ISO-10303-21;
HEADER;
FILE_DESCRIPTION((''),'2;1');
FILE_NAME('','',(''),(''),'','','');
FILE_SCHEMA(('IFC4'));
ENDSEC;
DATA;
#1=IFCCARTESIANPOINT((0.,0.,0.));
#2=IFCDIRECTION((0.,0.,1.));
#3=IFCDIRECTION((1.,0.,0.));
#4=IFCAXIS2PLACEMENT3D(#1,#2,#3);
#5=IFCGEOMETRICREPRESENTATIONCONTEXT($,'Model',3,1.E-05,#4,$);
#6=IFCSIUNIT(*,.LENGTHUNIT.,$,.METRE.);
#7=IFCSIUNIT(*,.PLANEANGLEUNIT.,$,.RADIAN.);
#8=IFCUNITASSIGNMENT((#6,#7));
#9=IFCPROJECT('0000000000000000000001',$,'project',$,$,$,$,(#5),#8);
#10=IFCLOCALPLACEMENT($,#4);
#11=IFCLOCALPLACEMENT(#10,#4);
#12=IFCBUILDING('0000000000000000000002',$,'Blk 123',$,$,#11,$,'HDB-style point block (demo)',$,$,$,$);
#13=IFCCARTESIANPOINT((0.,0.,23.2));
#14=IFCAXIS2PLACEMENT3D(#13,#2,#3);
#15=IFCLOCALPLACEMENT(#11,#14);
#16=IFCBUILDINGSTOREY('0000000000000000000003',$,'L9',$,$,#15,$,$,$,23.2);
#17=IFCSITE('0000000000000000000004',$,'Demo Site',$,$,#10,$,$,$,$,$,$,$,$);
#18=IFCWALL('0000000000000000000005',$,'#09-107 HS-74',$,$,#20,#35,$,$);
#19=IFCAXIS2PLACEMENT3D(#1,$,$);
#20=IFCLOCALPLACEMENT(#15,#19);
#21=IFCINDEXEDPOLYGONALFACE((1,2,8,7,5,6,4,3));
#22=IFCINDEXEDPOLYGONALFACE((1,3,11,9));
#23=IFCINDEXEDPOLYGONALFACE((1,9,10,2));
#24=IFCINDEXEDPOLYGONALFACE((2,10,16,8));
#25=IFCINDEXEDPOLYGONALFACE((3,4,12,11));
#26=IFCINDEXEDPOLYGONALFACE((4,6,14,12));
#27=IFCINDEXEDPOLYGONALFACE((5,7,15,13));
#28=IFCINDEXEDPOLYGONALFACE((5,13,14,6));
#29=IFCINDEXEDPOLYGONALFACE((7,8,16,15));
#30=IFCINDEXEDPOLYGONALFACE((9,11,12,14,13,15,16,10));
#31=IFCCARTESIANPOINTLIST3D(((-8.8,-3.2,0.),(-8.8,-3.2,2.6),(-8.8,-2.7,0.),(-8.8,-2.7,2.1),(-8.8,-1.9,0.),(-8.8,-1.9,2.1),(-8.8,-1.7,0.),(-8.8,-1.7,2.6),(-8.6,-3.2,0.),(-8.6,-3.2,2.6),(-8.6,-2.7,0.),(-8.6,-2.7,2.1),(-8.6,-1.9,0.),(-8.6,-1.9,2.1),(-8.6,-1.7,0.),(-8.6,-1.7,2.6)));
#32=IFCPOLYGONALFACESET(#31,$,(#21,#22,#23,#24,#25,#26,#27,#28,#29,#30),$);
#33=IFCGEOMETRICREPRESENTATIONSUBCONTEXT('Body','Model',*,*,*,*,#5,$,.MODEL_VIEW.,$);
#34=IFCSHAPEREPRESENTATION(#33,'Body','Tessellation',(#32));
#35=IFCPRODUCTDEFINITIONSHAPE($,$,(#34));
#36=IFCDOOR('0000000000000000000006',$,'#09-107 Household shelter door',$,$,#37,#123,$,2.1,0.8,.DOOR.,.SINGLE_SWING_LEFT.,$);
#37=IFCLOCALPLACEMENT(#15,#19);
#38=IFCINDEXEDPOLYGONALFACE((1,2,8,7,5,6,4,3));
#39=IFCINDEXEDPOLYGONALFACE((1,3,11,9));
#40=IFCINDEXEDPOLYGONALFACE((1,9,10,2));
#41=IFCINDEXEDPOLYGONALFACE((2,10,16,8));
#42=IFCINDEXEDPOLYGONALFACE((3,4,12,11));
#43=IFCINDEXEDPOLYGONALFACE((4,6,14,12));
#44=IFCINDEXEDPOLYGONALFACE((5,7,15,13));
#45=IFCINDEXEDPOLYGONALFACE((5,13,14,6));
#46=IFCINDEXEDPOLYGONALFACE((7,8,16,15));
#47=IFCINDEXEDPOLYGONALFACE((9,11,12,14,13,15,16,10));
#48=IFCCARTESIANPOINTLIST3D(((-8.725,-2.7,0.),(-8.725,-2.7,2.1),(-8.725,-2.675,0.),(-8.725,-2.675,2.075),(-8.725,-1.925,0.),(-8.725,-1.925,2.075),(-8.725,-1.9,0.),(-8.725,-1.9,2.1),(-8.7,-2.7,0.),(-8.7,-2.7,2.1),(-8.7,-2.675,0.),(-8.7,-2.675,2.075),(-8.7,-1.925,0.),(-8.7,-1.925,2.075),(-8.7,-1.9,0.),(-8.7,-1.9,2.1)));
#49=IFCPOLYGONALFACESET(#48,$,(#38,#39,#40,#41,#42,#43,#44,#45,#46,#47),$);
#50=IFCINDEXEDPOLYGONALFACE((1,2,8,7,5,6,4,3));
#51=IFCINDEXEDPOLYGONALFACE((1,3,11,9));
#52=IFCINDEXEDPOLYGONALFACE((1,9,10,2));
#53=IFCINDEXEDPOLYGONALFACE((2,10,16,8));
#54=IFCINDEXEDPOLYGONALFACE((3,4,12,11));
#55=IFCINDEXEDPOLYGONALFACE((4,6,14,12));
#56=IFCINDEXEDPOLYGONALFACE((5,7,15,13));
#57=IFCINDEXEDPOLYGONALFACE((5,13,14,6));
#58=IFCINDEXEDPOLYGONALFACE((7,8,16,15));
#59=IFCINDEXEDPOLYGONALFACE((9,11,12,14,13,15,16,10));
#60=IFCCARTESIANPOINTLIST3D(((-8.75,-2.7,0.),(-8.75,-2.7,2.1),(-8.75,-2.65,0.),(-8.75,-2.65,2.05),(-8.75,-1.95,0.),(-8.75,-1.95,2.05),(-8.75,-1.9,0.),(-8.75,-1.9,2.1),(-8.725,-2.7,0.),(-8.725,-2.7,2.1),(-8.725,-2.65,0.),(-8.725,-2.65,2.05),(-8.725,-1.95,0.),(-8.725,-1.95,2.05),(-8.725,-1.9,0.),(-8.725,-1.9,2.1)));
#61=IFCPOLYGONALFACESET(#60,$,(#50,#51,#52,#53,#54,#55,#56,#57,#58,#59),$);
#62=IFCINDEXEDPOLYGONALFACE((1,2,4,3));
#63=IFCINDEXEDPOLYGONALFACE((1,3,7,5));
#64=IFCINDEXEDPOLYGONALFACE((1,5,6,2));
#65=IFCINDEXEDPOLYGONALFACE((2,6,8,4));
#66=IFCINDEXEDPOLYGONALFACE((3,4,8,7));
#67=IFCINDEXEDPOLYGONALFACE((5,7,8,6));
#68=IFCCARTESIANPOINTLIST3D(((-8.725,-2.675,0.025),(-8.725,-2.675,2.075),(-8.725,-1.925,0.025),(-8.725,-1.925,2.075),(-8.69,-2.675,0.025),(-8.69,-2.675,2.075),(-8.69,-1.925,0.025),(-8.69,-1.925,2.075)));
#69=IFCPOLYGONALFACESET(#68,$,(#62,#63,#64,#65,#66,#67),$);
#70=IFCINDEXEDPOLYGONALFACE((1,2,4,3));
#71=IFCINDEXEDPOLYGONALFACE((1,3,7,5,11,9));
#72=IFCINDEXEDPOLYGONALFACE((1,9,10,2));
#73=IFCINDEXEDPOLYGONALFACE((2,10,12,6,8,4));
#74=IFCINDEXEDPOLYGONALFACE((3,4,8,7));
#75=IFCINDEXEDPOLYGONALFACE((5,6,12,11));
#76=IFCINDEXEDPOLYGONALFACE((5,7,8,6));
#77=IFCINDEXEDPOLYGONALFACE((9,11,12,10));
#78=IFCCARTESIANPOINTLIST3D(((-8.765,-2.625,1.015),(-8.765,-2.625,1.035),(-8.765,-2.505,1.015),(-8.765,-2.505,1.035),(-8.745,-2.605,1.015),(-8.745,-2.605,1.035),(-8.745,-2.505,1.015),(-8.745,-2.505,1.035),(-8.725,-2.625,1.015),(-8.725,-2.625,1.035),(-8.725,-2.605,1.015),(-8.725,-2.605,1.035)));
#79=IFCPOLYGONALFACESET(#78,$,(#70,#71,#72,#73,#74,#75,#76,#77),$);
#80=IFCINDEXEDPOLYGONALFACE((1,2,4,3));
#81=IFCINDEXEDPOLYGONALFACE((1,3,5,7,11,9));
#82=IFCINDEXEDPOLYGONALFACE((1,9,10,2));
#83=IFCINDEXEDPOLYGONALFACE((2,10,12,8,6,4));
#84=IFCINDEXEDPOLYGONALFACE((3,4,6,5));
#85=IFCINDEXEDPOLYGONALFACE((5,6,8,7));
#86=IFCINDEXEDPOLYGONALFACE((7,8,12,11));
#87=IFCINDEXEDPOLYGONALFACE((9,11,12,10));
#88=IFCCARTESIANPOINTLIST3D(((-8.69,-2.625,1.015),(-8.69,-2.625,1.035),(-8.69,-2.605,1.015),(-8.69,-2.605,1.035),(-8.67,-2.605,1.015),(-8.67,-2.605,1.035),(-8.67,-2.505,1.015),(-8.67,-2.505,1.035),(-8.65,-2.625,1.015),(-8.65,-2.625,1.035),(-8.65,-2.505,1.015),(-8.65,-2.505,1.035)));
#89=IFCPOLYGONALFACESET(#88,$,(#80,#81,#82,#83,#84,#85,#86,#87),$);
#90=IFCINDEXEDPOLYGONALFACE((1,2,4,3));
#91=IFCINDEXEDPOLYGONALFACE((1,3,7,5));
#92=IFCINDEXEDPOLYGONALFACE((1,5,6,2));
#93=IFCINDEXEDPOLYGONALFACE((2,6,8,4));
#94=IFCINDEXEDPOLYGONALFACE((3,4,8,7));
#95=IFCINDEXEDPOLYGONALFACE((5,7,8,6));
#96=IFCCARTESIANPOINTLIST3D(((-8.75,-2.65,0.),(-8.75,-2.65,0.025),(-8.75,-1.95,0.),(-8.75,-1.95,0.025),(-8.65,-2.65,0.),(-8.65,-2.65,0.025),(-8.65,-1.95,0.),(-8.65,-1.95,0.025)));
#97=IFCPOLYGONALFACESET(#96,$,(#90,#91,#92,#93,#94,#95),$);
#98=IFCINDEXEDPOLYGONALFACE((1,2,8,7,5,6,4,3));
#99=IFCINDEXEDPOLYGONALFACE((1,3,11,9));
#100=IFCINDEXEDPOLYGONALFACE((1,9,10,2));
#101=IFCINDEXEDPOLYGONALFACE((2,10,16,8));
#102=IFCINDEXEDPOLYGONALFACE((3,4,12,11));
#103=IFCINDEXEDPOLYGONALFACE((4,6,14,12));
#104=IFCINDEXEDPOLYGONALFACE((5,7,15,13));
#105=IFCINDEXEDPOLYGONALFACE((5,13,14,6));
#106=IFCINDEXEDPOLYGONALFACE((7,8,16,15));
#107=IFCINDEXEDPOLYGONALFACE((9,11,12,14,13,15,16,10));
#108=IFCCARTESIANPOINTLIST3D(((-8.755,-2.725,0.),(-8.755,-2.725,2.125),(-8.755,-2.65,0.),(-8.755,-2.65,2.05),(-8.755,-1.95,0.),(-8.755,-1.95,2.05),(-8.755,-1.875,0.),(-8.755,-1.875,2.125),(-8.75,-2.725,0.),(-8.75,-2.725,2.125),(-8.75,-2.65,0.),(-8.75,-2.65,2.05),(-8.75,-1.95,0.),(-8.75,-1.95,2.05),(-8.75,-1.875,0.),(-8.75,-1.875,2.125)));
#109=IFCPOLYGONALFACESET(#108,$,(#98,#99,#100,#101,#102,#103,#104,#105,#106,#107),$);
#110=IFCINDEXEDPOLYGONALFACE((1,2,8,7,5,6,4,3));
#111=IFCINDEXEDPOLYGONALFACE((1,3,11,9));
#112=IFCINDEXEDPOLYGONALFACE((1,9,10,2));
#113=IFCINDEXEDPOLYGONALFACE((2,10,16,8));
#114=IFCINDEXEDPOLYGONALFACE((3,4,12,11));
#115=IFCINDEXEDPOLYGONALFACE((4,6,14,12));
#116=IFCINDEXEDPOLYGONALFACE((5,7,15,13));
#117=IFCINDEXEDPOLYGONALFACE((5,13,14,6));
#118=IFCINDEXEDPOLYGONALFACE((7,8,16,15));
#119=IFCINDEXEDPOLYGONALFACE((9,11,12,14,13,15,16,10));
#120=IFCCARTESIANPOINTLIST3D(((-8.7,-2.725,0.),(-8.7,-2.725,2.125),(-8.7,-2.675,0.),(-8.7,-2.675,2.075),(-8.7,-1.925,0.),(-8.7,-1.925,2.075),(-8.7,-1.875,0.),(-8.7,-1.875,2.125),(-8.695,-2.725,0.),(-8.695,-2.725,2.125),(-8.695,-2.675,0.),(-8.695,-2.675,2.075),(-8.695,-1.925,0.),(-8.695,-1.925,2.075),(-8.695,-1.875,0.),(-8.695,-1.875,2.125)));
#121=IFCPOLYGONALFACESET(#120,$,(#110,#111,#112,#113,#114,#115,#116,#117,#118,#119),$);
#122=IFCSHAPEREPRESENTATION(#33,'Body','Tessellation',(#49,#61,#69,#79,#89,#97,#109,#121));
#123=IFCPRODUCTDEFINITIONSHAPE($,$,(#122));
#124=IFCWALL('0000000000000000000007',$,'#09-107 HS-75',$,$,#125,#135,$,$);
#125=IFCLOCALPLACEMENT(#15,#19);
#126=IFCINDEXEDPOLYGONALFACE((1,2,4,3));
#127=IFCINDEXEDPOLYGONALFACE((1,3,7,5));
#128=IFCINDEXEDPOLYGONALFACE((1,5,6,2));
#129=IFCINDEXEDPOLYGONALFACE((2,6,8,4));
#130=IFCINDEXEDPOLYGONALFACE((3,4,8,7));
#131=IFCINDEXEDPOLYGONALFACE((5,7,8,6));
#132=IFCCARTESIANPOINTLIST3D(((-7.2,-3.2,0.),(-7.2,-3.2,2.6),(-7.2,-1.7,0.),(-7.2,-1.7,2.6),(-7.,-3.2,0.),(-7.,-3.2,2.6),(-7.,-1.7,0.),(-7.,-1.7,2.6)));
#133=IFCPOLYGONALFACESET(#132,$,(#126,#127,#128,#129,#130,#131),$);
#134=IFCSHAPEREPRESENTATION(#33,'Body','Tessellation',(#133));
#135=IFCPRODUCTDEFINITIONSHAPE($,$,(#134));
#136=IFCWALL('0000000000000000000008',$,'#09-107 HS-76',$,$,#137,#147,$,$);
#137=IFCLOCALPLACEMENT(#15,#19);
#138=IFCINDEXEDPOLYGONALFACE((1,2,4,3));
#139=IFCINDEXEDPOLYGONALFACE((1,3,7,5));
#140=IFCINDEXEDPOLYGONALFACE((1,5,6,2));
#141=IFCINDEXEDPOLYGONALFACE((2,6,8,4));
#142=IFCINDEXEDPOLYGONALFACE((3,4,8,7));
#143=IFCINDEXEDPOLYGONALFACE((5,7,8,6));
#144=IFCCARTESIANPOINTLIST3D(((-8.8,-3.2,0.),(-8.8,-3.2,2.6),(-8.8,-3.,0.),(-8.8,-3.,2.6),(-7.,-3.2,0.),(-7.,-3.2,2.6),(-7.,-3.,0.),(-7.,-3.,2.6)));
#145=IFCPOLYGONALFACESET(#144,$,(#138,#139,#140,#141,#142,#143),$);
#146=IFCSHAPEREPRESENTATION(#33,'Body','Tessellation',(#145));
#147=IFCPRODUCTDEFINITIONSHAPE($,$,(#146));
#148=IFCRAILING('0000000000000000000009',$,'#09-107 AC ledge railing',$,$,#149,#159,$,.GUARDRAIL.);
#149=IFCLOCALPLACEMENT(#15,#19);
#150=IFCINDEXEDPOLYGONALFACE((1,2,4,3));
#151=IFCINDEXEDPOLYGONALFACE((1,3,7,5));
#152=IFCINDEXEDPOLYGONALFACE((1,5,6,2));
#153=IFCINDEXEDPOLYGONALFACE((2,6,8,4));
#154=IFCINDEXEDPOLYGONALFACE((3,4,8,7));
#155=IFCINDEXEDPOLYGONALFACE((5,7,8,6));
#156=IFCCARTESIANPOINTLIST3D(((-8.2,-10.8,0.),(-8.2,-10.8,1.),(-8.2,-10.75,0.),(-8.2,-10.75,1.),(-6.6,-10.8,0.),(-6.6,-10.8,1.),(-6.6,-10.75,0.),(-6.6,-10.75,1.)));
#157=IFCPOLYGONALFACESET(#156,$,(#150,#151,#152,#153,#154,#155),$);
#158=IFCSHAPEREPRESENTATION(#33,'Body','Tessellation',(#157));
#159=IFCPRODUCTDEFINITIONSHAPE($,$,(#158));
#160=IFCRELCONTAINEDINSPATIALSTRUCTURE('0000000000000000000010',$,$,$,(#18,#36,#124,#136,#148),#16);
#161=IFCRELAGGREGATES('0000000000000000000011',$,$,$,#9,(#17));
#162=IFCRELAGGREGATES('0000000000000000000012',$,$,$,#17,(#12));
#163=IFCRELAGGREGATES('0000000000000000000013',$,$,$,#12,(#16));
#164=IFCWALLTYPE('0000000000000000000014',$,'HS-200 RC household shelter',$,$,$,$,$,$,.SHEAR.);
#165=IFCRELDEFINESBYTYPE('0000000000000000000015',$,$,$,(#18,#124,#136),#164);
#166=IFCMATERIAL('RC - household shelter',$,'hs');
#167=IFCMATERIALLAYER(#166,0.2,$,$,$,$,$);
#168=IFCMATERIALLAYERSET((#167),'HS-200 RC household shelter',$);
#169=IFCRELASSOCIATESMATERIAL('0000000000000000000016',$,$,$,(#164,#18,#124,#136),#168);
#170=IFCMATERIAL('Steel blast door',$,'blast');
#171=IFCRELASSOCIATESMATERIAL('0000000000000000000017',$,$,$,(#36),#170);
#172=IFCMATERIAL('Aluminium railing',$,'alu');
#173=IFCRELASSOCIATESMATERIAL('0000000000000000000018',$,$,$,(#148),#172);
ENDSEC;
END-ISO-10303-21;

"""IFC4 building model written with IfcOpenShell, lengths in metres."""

from ifc_helpers import new_model, si_unit, frame, origin, origin_with_axes, place, context, subcontext, project, spatial, polyline, line, indexed_curve, outline, extrude, material, layer, layer_set, layer_usage, type_object, element, fill, save


model = new_model("IFC4")

# Units and contexts
model_context = context("Model", 3, precision=1e-05, world=origin_with_axes())
body_context = subcontext(model_context, "Body", "Model", "MODEL_VIEW")
ifc_project = project(units=[si_unit("LENGTHUNIT", "METRE"), si_unit("PLANEANGLEUNIT", "RADIAN")], contexts=[model_context])

# Site, building, storey
site_placement = place(None, origin_with_axes())
site = spatial("IfcSite", under=ifc_project, at=site_placement, Name="Demo Site")
building_placement = place(site_placement, origin_with_axes())
building = spatial("IfcBuilding", under=site, at=building_placement, Name="Blk 123", LongName="HDB-style point block (demo)")
storey_placement = place(building_placement, frame((0.0, 0.0, 23.2), z_axis=(0.0, 0.0, 1.0), x_axis=(1.0, 0.0, 0.0)))
storey = spatial("IfcBuildingStorey", under=building, at=storey_placement, Name="L9", Elevation=23.2)

# Wall, opening, door
ifc_material_1 = material(Name="RC - household shelter", Category="hs")
ifc_layer_1 = layer(ifc_material_1, 0.2)
ifc_layer_set_1 = layer_set([ifc_layer_1], Name="HS-200 RC household shelter")
ifc_layer_usage_1 = layer_usage(ifc_layer_set_1, "AXIS2", "POSITIVE", -0.1)
wall_type_1 = type_object("IfcWallType", Name="HS-200 RC household shelter", PredefinedType="SHEAR", material=ifc_layer_set_1)
wall_1_placement = place(storey_placement, frame((-8.7, -1.7, 0.0), z_axis=(0.0, 0.0, 1.0), x_axis=(0.0, -1.0, 0.0)))
wall_1 = element("IfcWall", 1, at=wall_1_placement, inside=storey, type_object=wall_type_1, material=ifc_layer_usage_1, Name="#09-107 HS-74", context=body_context, shape_type="SweptSolid", body=[
    extrude(outline(indexed_curve([(0.0, 0.0), (0.0, 0.2), (1.5, 0.2), (1.5, 0.0), (0.0, 0.0)], self_intersect=False)), frame((0.0, -0.1, 0.0), z_axis=(0.0, 0.0, 1.0), x_axis=(1.0, 0.0, 0.0)), (0.0, 0.0, 1.0), 2.6),
])
opening_1_placement = place(wall_1_placement, frame((0.2, -0.2, 0.0), z_axis=(0.0, 0.0, 1.0), x_axis=(1.0, 0.0, 0.0)))
opening_1 = element("IfcOpeningElement", 2, at=opening_1_placement, cuts=wall_1, context=body_context, shape_type="SweptSolid", body=[
    extrude(outline(indexed_curve([(0.0, 0.0), (0.0, 0.4), (0.8, 0.4), (0.8, 0.0), (0.0, 0.0)], self_intersect=False)), origin_with_axes(), (0.0, 0.0, 1.0), 2.1),
])
ifc_material_2 = material(Name="Steel blast door", Category="blast")
door_1_placement = place(opening_1_placement, frame((0.0, 0.15, 0.0), z_axis=(0.0, 0.0, 1.0), x_axis=(1.0, 0.0, 0.0)))
door_1 = element("IfcDoor", 3, at=door_1_placement, inside=storey, material=ifc_material_2, Name="#09-107 Household shelter door", OperationType="SINGLE_SWING_LEFT", OverallHeight=2.1, OverallWidth=0.8, PredefinedType="DOOR", context=body_context, shape_type="SweptSolid", body=[
    extrude(outline(indexed_curve([(0.0, 0.0), (0.0, 2.1), (0.8, 2.1), (0.8, 0.0), (0.775, 0.0), (0.775, 2.075), (0.025, 2.075), (0.025, 0.0)], segments=[line(1, 2, 3, 4, 5, 6, 7, 8, 1)])), frame((0.0, 0.025, 0.0), z_axis=(0.0, -1.0, 0.0), x_axis=(1.0, 0.0, 0.0)), (0.0, 0.0, -1.0), 0.025),
    extrude(outline(indexed_curve([(0.0, 0.0), (0.0, 2.1), (0.8, 2.1), (0.8, 0.0), (0.75, 0.0), (0.75, 2.05), (0.05, 2.05), (0.05, 0.0)], segments=[line(1, 2, 3, 4, 5, 6, 7, 8, 1)])), frame((0.0, 0.0, 0.0), z_axis=(0.0, -1.0, 0.0), x_axis=(1.0, 0.0, 0.0)), (0.0, 0.0, -1.0), 0.025),
    extrude(outline(indexed_curve([(0.0, 0.0), (0.75, 0.0), (0.75, 0.035), (0.0, 0.035)], segments=[line(1, 2, 3, 4, 1)])), frame((0.025, 0.025, 0.025), z_axis=(0.0, 0.0, 1.0), x_axis=(1.0, 0.0, 0.0)), (0.0, 0.0, 1.0), 2.05),
    extrude(outline(indexed_curve([(0.0, 0.0), (0.0, -0.04), (-0.12, -0.04), (-0.12, -0.02), (-0.02, -0.02), (-0.02, 0.0)], segments=[line(1, 2, 3, 4, 5, 6, 1)])), frame((0.725, 0.025, 1.015), z_axis=(0.0, 0.0, 1.0), x_axis=(1.0, 0.0, 0.0)), (0.0, 0.0, 1.0), 0.02),
    extrude(outline(indexed_curve([(0.0, 0.0), (0.0, 0.04), (-0.12, 0.04), (-0.12, 0.02), (-0.02, 0.02), (-0.02, 0.0)], segments=[line(1, 2, 3, 4, 5, 6, 1)])), frame((0.725, 0.06, 1.015), z_axis=(0.0, 0.0, 1.0), x_axis=(1.0, 0.0, 0.0)), (0.0, 0.0, 1.0), 0.02),
    extrude(outline(indexed_curve([(0.0, 0.0), (0.7, 0.0), (0.7, 0.1), (0.0, 0.1)], segments=[line(1, 2, 3, 4, 1)])), frame((0.05, 0.0, 0.0), z_axis=(0.0, 0.0, 1.0), x_axis=(1.0, 0.0, 0.0)), (0.0, 0.0, 1.0), 0.025),
    extrude(outline(indexed_curve([(0.0, 0.0), (0.0, 2.125), (0.85, 2.125), (0.85, 0.0), (0.775, 0.0), (0.775, 2.05), (0.075, 2.05), (0.075, 0.0)], segments=[line(1, 2, 3, 4, 5, 6, 7, 8, 1)])), frame((-0.025, -0.005, 0.0), z_axis=(0.0, -1.0, 0.0), x_axis=(1.0, 0.0, 0.0)), (0.0, 0.0, -1.0), 0.005),
    extrude(outline(indexed_curve([(0.0, 0.0), (0.0, 2.125), (0.85, 2.125), (0.85, 0.0), (0.8, 0.0), (0.8, 2.075), (0.05, 2.075), (0.05, 0.0)], segments=[line(1, 2, 3, 4, 5, 6, 7, 8, 1)])), frame((-0.025, 0.05, 0.0), z_axis=(0.0, -1.0, 0.0), x_axis=(1.0, 0.0, 0.0)), (0.0, 0.0, -1.0), 0.005),
])
fill(opening_1, door_1)

# Walls
wall_2_placement = place(storey_placement, frame((-7.1, -1.7, 0.0), z_axis=(0.0, 0.0, 1.0), x_axis=(0.0, -1.0, 0.0)))
element("IfcWall", 4, at=wall_2_placement, inside=storey, type_object=wall_type_1, material=ifc_layer_usage_1, Name="#09-107 HS-75", context=body_context, shape_type="SweptSolid", body=[
    extrude(outline(indexed_curve([(0.0, 0.0), (0.0, 0.2), (1.5, 0.2), (1.5, 0.0), (0.0, 0.0)], self_intersect=False)), frame((0.0, -0.1, 0.0), z_axis=(0.0, 0.0, 1.0), x_axis=(1.0, 0.0, 0.0)), (0.0, 0.0, 1.0), 2.6),
])
wall_3_placement = place(storey_placement, frame((-7.0, -3.1, 0.0), z_axis=(0.0, 0.0, 1.0), x_axis=(-1.0, 0.0, 0.0)))
element("IfcWall", 5, at=wall_3_placement, inside=storey, type_object=wall_type_1, material=ifc_layer_usage_1, Name="#09-107 HS-76", context=body_context, shape_type="SweptSolid", body=[
    extrude(outline(indexed_curve([(0.0, 0.0), (0.0, 0.2), (1.8, 0.2), (1.8, 0.0), (0.0, 0.0)], self_intersect=False)), frame((0.0, -0.1, 0.0), z_axis=(0.0, 0.0, 1.0), x_axis=(1.0, 0.0, 0.0)), (0.0, 0.0, 1.0), 2.6),
])

# Railing
ifc_material_3 = material(Name="Aluminium railing", Category="alu")
railing_placement = place(storey_placement, frame((-7.4, -10.775, 0.0), z_axis=(0.0, 0.0, 1.0), x_axis=(1.0, 0.0, 0.0)))
element("IfcRailing", 6, at=railing_placement, inside=storey, material=ifc_material_3, Name="#09-107 AC ledge railing", PredefinedType="GUARDRAIL", context=body_context, shape_type="SweptSolid", body=[
    extrude(outline(polyline([(-0.8, 0.025), (-0.8, -0.025), (0.8, -0.025), (0.8, 0.025), (-0.8, 0.025)])), origin(), (0.0, 0.0, 1.0), 1.0),
])

save(model, "model.ifc")
